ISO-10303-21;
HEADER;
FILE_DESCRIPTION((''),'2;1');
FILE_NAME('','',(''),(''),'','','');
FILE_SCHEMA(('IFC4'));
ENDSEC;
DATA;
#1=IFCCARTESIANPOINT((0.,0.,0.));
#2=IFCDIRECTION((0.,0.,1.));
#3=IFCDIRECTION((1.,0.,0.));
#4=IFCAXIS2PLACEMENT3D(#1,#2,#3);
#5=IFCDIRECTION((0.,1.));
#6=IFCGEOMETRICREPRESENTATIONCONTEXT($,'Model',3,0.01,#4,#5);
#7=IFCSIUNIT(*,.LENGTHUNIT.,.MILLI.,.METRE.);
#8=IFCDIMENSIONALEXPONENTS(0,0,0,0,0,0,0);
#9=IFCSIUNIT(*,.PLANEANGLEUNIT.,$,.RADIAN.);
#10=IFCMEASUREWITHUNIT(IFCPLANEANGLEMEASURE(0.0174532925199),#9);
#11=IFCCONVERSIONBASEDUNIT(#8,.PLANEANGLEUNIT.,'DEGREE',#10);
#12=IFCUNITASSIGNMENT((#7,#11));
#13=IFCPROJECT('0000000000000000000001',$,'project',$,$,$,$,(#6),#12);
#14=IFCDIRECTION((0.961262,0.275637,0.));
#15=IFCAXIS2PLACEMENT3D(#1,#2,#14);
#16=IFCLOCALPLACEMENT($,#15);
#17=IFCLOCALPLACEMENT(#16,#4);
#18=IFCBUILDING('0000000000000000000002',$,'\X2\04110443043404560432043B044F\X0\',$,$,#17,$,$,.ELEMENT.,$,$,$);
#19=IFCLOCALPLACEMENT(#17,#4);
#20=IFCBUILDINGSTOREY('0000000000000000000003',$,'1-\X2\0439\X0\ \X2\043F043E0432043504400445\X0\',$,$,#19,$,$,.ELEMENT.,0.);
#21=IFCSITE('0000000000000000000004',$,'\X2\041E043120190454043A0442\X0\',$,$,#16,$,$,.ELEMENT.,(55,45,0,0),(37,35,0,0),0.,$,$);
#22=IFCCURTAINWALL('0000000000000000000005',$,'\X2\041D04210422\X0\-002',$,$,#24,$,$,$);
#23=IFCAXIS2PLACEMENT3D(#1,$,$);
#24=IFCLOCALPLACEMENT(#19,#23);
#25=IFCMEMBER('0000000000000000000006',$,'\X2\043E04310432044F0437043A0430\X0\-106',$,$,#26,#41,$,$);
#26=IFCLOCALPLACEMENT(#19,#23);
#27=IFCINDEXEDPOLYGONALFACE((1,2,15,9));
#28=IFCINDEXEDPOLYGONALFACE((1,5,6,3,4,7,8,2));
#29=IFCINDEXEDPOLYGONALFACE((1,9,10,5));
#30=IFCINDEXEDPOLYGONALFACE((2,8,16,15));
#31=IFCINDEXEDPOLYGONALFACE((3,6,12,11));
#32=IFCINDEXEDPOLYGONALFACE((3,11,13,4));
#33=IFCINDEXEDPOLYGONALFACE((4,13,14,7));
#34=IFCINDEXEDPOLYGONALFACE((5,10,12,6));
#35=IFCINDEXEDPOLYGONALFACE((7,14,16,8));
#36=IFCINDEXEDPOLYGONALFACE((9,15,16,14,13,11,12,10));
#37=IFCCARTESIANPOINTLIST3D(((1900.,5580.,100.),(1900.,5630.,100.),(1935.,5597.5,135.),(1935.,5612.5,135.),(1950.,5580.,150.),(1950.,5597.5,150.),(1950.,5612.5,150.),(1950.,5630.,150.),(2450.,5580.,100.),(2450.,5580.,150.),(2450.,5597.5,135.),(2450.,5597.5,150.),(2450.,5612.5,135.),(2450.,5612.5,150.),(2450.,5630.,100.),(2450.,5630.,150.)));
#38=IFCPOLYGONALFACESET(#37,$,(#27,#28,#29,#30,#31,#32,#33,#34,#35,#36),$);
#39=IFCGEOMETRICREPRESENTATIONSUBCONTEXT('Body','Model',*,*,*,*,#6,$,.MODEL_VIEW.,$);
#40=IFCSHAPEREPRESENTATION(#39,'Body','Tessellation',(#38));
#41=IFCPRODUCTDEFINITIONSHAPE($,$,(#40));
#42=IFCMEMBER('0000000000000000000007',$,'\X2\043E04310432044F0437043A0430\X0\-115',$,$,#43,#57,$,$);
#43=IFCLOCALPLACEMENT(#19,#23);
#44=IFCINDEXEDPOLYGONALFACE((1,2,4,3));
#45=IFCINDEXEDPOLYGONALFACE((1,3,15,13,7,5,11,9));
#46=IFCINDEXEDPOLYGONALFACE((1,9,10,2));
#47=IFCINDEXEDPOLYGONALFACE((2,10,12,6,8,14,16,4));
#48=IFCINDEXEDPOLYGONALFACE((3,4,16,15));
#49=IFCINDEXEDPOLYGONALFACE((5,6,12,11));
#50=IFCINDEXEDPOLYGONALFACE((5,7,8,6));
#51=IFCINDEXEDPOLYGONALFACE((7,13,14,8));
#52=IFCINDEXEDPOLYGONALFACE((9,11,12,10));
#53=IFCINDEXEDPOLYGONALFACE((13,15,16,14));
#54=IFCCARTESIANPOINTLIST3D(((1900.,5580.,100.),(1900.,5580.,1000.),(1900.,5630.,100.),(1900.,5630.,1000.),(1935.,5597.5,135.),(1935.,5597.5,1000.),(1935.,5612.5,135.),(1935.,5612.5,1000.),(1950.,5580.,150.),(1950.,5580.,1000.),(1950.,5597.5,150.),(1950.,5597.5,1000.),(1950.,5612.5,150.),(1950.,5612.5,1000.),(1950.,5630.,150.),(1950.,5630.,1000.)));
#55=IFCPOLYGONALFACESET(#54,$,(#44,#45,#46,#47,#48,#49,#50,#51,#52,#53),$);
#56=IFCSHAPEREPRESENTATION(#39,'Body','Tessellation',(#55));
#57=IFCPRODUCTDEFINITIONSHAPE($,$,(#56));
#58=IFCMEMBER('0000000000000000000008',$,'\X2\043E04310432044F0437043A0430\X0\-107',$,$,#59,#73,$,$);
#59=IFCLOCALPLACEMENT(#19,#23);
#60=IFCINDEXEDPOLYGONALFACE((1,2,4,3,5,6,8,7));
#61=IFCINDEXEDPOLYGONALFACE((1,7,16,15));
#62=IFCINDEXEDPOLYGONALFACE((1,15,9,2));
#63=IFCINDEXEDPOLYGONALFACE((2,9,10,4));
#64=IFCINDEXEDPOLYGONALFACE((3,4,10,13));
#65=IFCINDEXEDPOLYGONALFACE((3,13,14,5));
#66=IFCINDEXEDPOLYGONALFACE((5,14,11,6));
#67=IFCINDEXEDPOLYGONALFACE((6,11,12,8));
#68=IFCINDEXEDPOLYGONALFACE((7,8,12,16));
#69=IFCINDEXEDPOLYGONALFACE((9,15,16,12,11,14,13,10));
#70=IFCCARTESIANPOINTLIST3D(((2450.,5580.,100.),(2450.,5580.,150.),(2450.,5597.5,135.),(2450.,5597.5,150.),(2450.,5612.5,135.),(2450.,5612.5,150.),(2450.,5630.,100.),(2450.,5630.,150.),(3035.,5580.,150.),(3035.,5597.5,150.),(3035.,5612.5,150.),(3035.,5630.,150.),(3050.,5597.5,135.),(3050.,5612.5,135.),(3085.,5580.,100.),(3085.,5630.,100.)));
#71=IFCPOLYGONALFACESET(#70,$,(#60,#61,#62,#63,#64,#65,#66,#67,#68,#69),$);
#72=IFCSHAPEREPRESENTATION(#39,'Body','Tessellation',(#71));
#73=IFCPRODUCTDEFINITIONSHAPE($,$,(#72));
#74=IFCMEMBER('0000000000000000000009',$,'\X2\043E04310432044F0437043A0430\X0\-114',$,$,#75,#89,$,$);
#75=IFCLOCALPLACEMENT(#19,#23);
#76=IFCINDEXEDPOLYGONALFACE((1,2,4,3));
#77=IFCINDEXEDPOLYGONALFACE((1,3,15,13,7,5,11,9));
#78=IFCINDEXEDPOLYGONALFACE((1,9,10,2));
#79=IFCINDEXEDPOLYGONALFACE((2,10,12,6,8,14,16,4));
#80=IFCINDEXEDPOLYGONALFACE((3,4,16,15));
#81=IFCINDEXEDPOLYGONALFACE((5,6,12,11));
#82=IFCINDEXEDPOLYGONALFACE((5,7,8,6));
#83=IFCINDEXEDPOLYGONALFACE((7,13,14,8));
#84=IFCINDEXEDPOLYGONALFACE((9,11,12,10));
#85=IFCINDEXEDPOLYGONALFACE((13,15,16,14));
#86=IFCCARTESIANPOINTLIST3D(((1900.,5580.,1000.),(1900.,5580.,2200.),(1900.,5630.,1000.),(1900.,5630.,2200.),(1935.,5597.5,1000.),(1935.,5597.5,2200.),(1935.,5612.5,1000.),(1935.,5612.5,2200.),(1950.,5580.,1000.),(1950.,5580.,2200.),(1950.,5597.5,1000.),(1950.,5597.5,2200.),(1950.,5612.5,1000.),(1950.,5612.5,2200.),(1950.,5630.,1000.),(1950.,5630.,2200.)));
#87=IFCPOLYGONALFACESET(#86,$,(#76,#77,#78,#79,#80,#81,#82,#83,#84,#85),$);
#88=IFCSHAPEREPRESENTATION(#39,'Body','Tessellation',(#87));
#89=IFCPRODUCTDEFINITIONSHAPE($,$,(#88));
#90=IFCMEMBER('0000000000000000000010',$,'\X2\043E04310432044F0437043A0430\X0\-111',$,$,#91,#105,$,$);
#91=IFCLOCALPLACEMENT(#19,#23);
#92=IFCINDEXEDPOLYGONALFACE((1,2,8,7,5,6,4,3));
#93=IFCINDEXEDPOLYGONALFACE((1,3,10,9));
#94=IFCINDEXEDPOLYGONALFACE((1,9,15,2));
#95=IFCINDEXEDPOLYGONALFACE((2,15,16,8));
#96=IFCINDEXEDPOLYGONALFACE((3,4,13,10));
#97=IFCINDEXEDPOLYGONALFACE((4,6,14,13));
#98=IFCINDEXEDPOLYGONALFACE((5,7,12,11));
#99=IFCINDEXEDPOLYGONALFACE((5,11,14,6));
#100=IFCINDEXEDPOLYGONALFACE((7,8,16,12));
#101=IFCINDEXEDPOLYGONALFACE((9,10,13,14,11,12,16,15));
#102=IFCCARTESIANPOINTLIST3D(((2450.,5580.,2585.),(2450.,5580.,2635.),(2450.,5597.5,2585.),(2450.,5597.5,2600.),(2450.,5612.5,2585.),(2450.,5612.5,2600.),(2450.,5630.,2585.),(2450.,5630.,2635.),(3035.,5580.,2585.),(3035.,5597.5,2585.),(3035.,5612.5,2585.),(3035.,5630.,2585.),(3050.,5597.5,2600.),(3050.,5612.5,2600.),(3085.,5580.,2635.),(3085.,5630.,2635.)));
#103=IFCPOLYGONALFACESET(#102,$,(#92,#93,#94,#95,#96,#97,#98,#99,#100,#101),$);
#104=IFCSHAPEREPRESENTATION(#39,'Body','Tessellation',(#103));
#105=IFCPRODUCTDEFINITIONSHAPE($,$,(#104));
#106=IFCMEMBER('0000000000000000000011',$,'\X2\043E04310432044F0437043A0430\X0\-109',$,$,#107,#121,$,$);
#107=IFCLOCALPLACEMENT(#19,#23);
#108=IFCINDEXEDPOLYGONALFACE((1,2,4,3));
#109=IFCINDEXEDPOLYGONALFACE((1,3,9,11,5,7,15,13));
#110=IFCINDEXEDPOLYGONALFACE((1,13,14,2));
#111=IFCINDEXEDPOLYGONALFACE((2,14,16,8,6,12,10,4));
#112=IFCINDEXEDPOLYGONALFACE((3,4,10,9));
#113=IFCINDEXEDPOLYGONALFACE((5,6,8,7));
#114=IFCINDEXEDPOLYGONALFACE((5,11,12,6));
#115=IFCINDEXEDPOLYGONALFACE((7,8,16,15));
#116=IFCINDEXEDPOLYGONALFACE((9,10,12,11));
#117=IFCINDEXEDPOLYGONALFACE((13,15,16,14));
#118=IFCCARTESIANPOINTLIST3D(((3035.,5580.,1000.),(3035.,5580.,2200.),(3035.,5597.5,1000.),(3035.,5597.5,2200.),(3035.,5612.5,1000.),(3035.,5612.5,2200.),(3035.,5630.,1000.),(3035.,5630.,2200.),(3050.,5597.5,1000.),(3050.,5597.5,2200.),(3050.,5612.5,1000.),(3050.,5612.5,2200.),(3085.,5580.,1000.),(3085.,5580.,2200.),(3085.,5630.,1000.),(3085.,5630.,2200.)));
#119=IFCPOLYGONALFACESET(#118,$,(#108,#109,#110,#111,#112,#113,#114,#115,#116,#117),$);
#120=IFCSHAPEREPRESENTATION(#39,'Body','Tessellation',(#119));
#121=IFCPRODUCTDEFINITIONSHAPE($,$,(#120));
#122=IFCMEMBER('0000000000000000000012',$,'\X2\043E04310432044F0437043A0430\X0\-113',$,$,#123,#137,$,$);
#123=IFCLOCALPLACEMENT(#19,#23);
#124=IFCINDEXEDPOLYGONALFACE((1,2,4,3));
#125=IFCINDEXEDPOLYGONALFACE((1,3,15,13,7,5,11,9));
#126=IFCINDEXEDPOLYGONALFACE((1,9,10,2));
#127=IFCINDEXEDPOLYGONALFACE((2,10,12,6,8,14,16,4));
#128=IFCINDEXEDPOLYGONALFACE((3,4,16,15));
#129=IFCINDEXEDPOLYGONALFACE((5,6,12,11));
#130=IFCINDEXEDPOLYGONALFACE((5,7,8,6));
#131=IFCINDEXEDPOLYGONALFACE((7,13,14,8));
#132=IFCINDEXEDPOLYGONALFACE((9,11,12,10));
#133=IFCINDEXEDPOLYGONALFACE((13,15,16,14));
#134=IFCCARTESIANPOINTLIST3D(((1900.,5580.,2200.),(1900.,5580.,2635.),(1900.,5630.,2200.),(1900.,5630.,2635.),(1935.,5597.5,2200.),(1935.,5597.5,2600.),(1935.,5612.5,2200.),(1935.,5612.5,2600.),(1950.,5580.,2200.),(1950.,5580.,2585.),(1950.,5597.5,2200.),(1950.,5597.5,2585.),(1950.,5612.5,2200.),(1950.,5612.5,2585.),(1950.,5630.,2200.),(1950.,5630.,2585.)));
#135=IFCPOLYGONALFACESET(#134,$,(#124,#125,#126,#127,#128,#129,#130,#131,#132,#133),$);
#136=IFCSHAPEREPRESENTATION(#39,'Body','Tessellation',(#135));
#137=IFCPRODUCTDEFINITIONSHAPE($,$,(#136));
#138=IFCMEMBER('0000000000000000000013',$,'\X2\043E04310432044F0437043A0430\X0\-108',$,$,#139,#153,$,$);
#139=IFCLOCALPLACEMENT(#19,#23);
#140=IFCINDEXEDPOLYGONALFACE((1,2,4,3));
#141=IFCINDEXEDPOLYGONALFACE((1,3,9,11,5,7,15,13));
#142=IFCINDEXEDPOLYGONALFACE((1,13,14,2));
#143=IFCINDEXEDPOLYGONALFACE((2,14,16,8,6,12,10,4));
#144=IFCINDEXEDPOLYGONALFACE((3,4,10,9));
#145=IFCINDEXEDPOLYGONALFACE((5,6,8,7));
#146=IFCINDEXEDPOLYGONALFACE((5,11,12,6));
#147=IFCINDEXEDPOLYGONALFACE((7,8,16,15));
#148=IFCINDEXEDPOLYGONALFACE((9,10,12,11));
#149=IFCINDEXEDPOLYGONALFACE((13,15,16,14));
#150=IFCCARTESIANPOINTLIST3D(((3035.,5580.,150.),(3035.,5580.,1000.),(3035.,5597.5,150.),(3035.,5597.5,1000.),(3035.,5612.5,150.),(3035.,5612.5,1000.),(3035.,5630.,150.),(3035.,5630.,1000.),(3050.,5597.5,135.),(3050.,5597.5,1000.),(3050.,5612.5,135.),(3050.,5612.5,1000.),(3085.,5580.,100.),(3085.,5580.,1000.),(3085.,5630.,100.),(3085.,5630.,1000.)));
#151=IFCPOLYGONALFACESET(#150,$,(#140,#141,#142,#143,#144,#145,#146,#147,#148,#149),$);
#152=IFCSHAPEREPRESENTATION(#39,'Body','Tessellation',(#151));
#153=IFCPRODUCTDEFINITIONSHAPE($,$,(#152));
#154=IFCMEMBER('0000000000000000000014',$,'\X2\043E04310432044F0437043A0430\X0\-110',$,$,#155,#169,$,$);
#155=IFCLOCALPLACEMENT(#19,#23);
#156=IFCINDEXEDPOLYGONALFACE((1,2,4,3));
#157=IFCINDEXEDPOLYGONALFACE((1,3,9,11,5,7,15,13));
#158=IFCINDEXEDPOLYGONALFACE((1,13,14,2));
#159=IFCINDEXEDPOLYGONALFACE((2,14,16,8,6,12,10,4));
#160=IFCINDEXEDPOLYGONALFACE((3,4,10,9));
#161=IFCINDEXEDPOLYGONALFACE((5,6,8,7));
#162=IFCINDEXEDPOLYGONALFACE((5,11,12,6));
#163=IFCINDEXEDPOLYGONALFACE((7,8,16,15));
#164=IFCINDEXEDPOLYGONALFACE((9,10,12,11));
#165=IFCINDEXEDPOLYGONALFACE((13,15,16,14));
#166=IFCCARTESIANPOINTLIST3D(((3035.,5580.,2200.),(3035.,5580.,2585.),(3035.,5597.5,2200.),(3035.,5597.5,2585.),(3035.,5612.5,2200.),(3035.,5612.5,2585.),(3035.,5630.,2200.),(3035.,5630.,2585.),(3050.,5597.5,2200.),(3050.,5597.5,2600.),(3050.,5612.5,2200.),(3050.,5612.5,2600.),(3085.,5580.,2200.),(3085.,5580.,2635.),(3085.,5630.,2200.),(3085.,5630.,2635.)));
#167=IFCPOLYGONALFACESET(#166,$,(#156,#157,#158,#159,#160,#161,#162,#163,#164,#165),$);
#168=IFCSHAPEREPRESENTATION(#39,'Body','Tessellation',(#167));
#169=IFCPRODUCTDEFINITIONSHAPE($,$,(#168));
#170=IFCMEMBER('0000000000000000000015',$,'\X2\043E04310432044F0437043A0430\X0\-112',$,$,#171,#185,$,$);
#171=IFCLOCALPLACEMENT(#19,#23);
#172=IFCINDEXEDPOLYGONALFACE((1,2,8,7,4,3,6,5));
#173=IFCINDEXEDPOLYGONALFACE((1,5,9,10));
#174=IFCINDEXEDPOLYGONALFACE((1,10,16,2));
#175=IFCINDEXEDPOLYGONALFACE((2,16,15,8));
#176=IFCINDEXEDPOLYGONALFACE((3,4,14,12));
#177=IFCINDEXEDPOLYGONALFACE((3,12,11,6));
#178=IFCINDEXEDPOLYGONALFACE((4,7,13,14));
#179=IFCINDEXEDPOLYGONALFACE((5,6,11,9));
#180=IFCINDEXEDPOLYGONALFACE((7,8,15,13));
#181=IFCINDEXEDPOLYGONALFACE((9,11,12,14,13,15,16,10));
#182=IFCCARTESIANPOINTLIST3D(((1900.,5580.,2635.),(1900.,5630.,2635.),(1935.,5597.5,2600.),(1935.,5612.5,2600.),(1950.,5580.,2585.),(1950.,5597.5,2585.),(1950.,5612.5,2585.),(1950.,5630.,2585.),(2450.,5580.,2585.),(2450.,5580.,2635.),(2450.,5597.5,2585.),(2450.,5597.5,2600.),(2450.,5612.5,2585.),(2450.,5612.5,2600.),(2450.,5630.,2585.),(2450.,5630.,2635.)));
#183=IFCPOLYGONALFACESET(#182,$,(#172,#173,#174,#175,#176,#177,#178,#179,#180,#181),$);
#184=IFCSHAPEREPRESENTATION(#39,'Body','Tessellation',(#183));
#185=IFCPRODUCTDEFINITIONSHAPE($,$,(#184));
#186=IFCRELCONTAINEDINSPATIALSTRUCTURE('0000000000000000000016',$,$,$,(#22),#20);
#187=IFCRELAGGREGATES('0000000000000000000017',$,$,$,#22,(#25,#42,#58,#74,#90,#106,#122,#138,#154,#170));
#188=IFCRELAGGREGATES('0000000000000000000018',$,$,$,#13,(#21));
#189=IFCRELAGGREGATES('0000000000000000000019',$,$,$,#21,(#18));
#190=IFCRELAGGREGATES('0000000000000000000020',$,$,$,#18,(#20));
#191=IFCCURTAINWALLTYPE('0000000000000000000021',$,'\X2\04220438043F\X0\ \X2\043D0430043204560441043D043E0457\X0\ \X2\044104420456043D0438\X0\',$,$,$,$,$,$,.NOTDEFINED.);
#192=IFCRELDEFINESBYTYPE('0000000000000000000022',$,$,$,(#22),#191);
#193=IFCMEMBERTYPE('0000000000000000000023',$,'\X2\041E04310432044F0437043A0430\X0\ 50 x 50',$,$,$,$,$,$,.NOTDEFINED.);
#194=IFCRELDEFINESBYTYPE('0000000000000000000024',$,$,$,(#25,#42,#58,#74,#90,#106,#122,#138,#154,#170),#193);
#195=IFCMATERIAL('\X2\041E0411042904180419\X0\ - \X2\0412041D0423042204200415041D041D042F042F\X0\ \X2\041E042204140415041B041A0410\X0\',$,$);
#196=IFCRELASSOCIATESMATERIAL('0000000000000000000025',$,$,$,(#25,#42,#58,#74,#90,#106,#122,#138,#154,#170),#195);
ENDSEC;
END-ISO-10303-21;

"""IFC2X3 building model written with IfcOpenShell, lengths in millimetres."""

from ifc_helpers import new_model, entity, si_unit, converted_unit, direction, frame, origin_with_axes, place, context, subcontext, project, spatial, polyline, outline, extrude, clip, halfspace, material, type_object, element, aggregate, save


model = new_model("IFC2X3")

# Units and contexts
model_context = context("Model", 3, precision=0.01, world=origin_with_axes(), true_north=direction((0.0, 1.0)))
body_context = subcontext(model_context, "Body", "Model", "MODEL_VIEW")
ifc_project = project(units=[si_unit("LENGTHUNIT", "METRE", prefix="MILLI"), converted_unit("PLANEANGLEUNIT", "DEGREE", entity("IfcPlaneAngleMeasure", 0.0174532925199), si_unit("PLANEANGLEUNIT", "RADIAN"), dimensions=[0, 0, 0, 0, 0, 0, 0])], contexts=[model_context])

# Site, building, storey
site_placement = place(None, frame((0.0, 0.0, 0.0), z_axis=(0.0, 0.0, 1.0), x_axis=(0.961262, 0.275637, 0.0)))
site = spatial("IfcSite", under=ifc_project, at=site_placement, Name="Об’єкт", CompositionType="ELEMENT", RefLatitude=(55, 45, 0, 0), RefLongitude=(37, 35, 0, 0), RefElevation=0.0)
building_placement = place(site_placement, origin_with_axes())
building = spatial("IfcBuilding", under=site, at=building_placement, Name="Будівля", CompositionType="ELEMENT")
storey_placement = place(building_placement, origin_with_axes())
storey = spatial("IfcBuildingStorey", under=building, at=storey_placement, Name="1-й поверх", CompositionType="ELEMENT", Elevation=0.0)

# Curtain wall, members
curtain_wall_type = type_object("IfcCurtainWallType", Name="Тип навісної стіни", PredefinedType="NOTDEFINED")
curtain_wall_placement = place(storey_placement, frame((2175.0, 5605.0, 100.0), z_axis=(0.0, 0.0, 1.0), x_axis=(1.0, 0.0, 0.0)))
curtain_wall = element("IfcCurtainWall", 1, at=curtain_wall_placement, inside=storey, type_object=curtain_wall_type, Name="НСТ-002")
ifc_material_1 = material(Name="ОБЩИЙ - ВНУТРЕННЯЯ ОТДЕЛКА")
member_type_1 = type_object("IfcMemberType", Name="Обвязка 50 x 50", PredefinedType="NOTDEFINED")
member_1_placement = place(curtain_wall_placement, frame((-275.0, 0.0, 0.0), z_axis=(1.0, 0.0, 0.0), x_axis=(0.0, 0.0, 1.0)))
member_1 = element("IfcMember", 2, at=member_1_placement, type_object=member_type_1, material=ifc_material_1, Name="обвязка-106", context=body_context, shape_type="Clipping", body=[
    clip(extrude(outline(polyline([(-7.5, -35.0), (7.5, -35.0), (7.5, -50.0), (25.0, -50.0), (25.0, 0.0), (-25.0, 0.0), (-25.0, -50.0), (-7.5, -50.0), (-7.5, -35.0)])), frame((0.0, 0.0, 0.0), z_axis=(0.0, 0.0, 1.0), x_axis=(0.0, 1.0, 0.0)), (0.0, 0.0, 1.0), 550.0), halfspace(frame((0.0, 0.0, 0.0), z_axis=(-0.707107, 0.0, 0.707107), x_axis=(0.0, -1.0, 0.0)), True)),
])
member_2_placement = place(curtain_wall_placement, frame((-275.0, 0.0, 0.0), z_axis=(0.0, 0.0, 1.0), x_axis=(-1.0, 0.0, 0.0)))
member_2 = element("IfcMember", 3, at=member_2_placement, type_object=member_type_1, material=ifc_material_1, Name="обвязка-115", context=body_context, shape_type="Clipping", body=[
    clip(extrude(outline(polyline([(35.0, 7.5), (50.0, 7.5), (50.0, 25.0), (0.0, 25.0), (0.0, -25.0), (50.0, -25.0), (50.0, -7.5), (35.0, -7.5), (35.0, 7.5)])), frame((0.0, 0.0, 0.0), z_axis=(0.0, 0.0, 1.0), x_axis=(-1.0, 0.0, 0.0)), (0.0, 0.0, 1.0), 900.0), halfspace(frame((0.0, 0.0, 0.0), z_axis=(0.707107, 0.0, 0.707107), x_axis=(0.0, -1.0, 0.0)), True)),
])
member_3_placement = place(curtain_wall_placement, frame((275.0, 0.0, 0.0), z_axis=(1.0, 0.0, 0.0), x_axis=(0.0, 0.0, 1.0)))
member_3 = element("IfcMember", 4, at=member_3_placement, type_object=member_type_1, material=ifc_material_1, Name="обвязка-107", context=body_context, shape_type="Clipping", body=[
    clip(extrude(outline(polyline([(-7.5, -35.0), (7.5, -35.0), (7.5, -50.0), (25.0, -50.0), (25.0, 0.0), (-25.0, 0.0), (-25.0, -50.0), (-7.5, -50.0), (-7.5, -35.0)])), frame((0.0, 0.0, 0.0), z_axis=(0.0, 0.0, 1.0), x_axis=(0.0, 1.0, 0.0)), (0.0, 0.0, 1.0), 635.0), halfspace(frame((317.5, 0.0, 317.5), z_axis=(-0.707107, 0.0, -0.707107), x_axis=(0.0, 1.0, 0.0)), True)),
])
member_4_placement = place(curtain_wall_placement, frame((-275.0, 0.0, 900.0), z_axis=(0.0, 0.0, 1.0), x_axis=(-1.0, 0.0, 0.0)))
member_4 = element("IfcMember", 5, at=member_4_placement, type_object=member_type_1, material=ifc_material_1, Name="обвязка-114", context=body_context, shape_type="SweptSolid", body=[
    extrude(outline(polyline([(35.0, 7.5), (50.0, 7.5), (50.0, 25.0), (0.0, 25.0), (0.0, -25.0), (50.0, -25.0), (50.0, -7.5), (35.0, -7.5), (35.0, 7.5)])), frame((0.0, 0.0, 0.0), z_axis=(0.0, 0.0, 1.0), x_axis=(-1.0, 0.0, 0.0)), (0.0, 0.0, 1.0), 1200.0),
])
member_5_placement = place(curtain_wall_placement, frame((275.0, 0.0, 2535.0), z_axis=(1.0, 0.0, 0.0), x_axis=(0.0, 0.0, 1.0)))
member_5 = element("IfcMember", 6, at=member_5_placement, type_object=member_type_1, material=ifc_material_1, Name="обвязка-111", context=body_context, shape_type="Clipping", body=[
    clip(extrude(outline(polyline([(-7.5, 35.0), (-7.5, 50.0), (-25.0, 50.0), (-25.0, 0.0), (25.0, 0.0), (25.0, 50.0), (7.5, 50.0), (7.5, 35.0), (-7.5, 35.0)])), frame((0.0, 0.0, 0.0), z_axis=(0.0, 0.0, 1.0), x_axis=(0.0, 1.0, 0.0)), (0.0, 0.0, 1.0), 635.0), halfspace(frame((-317.5, 0.0, 317.5), z_axis=(0.707107, 0.0, -0.707107), x_axis=(0.0, 1.0, 0.0)), True)),
])
member_6_placement = place(curtain_wall_placement, frame((910.0, 0.0, 900.0), z_axis=(0.0, 0.0, 1.0), x_axis=(-1.0, 0.0, 0.0)))
member_6 = element("IfcMember", 7, at=member_6_placement, type_object=member_type_1, material=ifc_material_1, Name="обвязка-109", context=body_context, shape_type="SweptSolid", body=[
    extrude(outline(polyline([(-35.0, 7.5), (-35.0, -7.5), (-50.0, -7.5), (-50.0, -25.0), (0.0, -25.0), (0.0, 25.0), (-50.0, 25.0), (-50.0, 7.5), (-35.0, 7.5)])), frame((0.0, 0.0, 0.0), z_axis=(0.0, 0.0, 1.0), x_axis=(-1.0, 0.0, 0.0)), (0.0, 0.0, 1.0), 1200.0),
])
member_7_placement = place(curtain_wall_placement, frame((-275.0, 0.0, 2100.0), z_axis=(0.0, 0.0, 1.0), x_axis=(-1.0, 0.0, 0.0)))
member_7 = element("IfcMember", 8, at=member_7_placement, type_object=member_type_1, material=ifc_material_1, Name="обвязка-113", context=body_context, shape_type="Clipping", body=[
    clip(extrude(outline(polyline([(35.0, 7.5), (50.0, 7.5), (50.0, 25.0), (0.0, 25.0), (0.0, -25.0), (50.0, -25.0), (50.0, -7.5), (35.0, -7.5), (35.0, 7.5)])), frame((0.0, 0.0, 0.0), z_axis=(0.0, 0.0, 1.0), x_axis=(-1.0, 0.0, 0.0)), (0.0, 0.0, 1.0), 435.0), halfspace(frame((-217.5, 0.0, 217.5), z_axis=(0.707107, 0.0, -0.707107), x_axis=(0.0, 1.0, 0.0)), True)),
])
member_8_placement = place(curtain_wall_placement, frame((910.0, 0.0, 0.0), z_axis=(0.0, 0.0, 1.0), x_axis=(-1.0, 0.0, 0.0)))
member_8 = element("IfcMember", 9, at=member_8_placement, type_object=member_type_1, material=ifc_material_1, Name="обвязка-108", context=body_context, shape_type="Clipping", body=[
    clip(extrude(outline(polyline([(-35.0, 7.5), (-35.0, -7.5), (-50.0, -7.5), (-50.0, -25.0), (0.0, -25.0), (0.0, 25.0), (-50.0, 25.0), (-50.0, 7.5), (-35.0, 7.5)])), frame((0.0, 0.0, 0.0), z_axis=(0.0, 0.0, 1.0), x_axis=(-1.0, 0.0, 0.0)), (0.0, 0.0, 1.0), 900.0), halfspace(frame((0.0, 0.0, 0.0), z_axis=(-0.707107, 0.0, 0.707107), x_axis=(0.0, -1.0, 0.0)), True)),
])
member_9_placement = place(curtain_wall_placement, frame((910.0, 0.0, 2100.0), z_axis=(0.0, 0.0, 1.0), x_axis=(-1.0, 0.0, 0.0)))
member_9 = element("IfcMember", 10, at=member_9_placement, type_object=member_type_1, material=ifc_material_1, Name="обвязка-110", context=body_context, shape_type="Clipping", body=[
    clip(extrude(outline(polyline([(-35.0, 7.5), (-35.0, -7.5), (-50.0, -7.5), (-50.0, -25.0), (0.0, -25.0), (0.0, 25.0), (-50.0, 25.0), (-50.0, 7.5), (-35.0, 7.5)])), frame((0.0, 0.0, 0.0), z_axis=(0.0, 0.0, 1.0), x_axis=(-1.0, 0.0, 0.0)), (0.0, 0.0, 1.0), 435.0), halfspace(frame((217.5, 0.0, 217.5), z_axis=(-0.707107, 0.0, -0.707107), x_axis=(0.0, 1.0, 0.0)), True)),
])
member_10_placement = place(curtain_wall_placement, frame((-275.0, 0.0, 2535.0), z_axis=(1.0, 0.0, 0.0), x_axis=(0.0, 0.0, 1.0)))
member_10 = element("IfcMember", 11, at=member_10_placement, type_object=member_type_1, material=ifc_material_1, Name="обвязка-112", context=body_context, shape_type="Clipping", body=[
    clip(extrude(outline(polyline([(-7.5, 35.0), (-7.5, 50.0), (-25.0, 50.0), (-25.0, 0.0), (25.0, 0.0), (25.0, 50.0), (7.5, 50.0), (7.5, 35.0), (-7.5, 35.0)])), frame((0.0, 0.0, 0.0), z_axis=(0.0, 0.0, 1.0), x_axis=(0.0, 1.0, 0.0)), (0.0, 0.0, 1.0), 550.0), halfspace(frame((0.0, 0.0, 0.0), z_axis=(0.707107, 0.0, 0.707107), x_axis=(0.0, -1.0, 0.0)), True)),
])

aggregate(curtain_wall, [member_1, member_2, member_3, member_4, member_5, member_6, member_7, member_8, member_9, member_10])

save(model, "model.ifc")
